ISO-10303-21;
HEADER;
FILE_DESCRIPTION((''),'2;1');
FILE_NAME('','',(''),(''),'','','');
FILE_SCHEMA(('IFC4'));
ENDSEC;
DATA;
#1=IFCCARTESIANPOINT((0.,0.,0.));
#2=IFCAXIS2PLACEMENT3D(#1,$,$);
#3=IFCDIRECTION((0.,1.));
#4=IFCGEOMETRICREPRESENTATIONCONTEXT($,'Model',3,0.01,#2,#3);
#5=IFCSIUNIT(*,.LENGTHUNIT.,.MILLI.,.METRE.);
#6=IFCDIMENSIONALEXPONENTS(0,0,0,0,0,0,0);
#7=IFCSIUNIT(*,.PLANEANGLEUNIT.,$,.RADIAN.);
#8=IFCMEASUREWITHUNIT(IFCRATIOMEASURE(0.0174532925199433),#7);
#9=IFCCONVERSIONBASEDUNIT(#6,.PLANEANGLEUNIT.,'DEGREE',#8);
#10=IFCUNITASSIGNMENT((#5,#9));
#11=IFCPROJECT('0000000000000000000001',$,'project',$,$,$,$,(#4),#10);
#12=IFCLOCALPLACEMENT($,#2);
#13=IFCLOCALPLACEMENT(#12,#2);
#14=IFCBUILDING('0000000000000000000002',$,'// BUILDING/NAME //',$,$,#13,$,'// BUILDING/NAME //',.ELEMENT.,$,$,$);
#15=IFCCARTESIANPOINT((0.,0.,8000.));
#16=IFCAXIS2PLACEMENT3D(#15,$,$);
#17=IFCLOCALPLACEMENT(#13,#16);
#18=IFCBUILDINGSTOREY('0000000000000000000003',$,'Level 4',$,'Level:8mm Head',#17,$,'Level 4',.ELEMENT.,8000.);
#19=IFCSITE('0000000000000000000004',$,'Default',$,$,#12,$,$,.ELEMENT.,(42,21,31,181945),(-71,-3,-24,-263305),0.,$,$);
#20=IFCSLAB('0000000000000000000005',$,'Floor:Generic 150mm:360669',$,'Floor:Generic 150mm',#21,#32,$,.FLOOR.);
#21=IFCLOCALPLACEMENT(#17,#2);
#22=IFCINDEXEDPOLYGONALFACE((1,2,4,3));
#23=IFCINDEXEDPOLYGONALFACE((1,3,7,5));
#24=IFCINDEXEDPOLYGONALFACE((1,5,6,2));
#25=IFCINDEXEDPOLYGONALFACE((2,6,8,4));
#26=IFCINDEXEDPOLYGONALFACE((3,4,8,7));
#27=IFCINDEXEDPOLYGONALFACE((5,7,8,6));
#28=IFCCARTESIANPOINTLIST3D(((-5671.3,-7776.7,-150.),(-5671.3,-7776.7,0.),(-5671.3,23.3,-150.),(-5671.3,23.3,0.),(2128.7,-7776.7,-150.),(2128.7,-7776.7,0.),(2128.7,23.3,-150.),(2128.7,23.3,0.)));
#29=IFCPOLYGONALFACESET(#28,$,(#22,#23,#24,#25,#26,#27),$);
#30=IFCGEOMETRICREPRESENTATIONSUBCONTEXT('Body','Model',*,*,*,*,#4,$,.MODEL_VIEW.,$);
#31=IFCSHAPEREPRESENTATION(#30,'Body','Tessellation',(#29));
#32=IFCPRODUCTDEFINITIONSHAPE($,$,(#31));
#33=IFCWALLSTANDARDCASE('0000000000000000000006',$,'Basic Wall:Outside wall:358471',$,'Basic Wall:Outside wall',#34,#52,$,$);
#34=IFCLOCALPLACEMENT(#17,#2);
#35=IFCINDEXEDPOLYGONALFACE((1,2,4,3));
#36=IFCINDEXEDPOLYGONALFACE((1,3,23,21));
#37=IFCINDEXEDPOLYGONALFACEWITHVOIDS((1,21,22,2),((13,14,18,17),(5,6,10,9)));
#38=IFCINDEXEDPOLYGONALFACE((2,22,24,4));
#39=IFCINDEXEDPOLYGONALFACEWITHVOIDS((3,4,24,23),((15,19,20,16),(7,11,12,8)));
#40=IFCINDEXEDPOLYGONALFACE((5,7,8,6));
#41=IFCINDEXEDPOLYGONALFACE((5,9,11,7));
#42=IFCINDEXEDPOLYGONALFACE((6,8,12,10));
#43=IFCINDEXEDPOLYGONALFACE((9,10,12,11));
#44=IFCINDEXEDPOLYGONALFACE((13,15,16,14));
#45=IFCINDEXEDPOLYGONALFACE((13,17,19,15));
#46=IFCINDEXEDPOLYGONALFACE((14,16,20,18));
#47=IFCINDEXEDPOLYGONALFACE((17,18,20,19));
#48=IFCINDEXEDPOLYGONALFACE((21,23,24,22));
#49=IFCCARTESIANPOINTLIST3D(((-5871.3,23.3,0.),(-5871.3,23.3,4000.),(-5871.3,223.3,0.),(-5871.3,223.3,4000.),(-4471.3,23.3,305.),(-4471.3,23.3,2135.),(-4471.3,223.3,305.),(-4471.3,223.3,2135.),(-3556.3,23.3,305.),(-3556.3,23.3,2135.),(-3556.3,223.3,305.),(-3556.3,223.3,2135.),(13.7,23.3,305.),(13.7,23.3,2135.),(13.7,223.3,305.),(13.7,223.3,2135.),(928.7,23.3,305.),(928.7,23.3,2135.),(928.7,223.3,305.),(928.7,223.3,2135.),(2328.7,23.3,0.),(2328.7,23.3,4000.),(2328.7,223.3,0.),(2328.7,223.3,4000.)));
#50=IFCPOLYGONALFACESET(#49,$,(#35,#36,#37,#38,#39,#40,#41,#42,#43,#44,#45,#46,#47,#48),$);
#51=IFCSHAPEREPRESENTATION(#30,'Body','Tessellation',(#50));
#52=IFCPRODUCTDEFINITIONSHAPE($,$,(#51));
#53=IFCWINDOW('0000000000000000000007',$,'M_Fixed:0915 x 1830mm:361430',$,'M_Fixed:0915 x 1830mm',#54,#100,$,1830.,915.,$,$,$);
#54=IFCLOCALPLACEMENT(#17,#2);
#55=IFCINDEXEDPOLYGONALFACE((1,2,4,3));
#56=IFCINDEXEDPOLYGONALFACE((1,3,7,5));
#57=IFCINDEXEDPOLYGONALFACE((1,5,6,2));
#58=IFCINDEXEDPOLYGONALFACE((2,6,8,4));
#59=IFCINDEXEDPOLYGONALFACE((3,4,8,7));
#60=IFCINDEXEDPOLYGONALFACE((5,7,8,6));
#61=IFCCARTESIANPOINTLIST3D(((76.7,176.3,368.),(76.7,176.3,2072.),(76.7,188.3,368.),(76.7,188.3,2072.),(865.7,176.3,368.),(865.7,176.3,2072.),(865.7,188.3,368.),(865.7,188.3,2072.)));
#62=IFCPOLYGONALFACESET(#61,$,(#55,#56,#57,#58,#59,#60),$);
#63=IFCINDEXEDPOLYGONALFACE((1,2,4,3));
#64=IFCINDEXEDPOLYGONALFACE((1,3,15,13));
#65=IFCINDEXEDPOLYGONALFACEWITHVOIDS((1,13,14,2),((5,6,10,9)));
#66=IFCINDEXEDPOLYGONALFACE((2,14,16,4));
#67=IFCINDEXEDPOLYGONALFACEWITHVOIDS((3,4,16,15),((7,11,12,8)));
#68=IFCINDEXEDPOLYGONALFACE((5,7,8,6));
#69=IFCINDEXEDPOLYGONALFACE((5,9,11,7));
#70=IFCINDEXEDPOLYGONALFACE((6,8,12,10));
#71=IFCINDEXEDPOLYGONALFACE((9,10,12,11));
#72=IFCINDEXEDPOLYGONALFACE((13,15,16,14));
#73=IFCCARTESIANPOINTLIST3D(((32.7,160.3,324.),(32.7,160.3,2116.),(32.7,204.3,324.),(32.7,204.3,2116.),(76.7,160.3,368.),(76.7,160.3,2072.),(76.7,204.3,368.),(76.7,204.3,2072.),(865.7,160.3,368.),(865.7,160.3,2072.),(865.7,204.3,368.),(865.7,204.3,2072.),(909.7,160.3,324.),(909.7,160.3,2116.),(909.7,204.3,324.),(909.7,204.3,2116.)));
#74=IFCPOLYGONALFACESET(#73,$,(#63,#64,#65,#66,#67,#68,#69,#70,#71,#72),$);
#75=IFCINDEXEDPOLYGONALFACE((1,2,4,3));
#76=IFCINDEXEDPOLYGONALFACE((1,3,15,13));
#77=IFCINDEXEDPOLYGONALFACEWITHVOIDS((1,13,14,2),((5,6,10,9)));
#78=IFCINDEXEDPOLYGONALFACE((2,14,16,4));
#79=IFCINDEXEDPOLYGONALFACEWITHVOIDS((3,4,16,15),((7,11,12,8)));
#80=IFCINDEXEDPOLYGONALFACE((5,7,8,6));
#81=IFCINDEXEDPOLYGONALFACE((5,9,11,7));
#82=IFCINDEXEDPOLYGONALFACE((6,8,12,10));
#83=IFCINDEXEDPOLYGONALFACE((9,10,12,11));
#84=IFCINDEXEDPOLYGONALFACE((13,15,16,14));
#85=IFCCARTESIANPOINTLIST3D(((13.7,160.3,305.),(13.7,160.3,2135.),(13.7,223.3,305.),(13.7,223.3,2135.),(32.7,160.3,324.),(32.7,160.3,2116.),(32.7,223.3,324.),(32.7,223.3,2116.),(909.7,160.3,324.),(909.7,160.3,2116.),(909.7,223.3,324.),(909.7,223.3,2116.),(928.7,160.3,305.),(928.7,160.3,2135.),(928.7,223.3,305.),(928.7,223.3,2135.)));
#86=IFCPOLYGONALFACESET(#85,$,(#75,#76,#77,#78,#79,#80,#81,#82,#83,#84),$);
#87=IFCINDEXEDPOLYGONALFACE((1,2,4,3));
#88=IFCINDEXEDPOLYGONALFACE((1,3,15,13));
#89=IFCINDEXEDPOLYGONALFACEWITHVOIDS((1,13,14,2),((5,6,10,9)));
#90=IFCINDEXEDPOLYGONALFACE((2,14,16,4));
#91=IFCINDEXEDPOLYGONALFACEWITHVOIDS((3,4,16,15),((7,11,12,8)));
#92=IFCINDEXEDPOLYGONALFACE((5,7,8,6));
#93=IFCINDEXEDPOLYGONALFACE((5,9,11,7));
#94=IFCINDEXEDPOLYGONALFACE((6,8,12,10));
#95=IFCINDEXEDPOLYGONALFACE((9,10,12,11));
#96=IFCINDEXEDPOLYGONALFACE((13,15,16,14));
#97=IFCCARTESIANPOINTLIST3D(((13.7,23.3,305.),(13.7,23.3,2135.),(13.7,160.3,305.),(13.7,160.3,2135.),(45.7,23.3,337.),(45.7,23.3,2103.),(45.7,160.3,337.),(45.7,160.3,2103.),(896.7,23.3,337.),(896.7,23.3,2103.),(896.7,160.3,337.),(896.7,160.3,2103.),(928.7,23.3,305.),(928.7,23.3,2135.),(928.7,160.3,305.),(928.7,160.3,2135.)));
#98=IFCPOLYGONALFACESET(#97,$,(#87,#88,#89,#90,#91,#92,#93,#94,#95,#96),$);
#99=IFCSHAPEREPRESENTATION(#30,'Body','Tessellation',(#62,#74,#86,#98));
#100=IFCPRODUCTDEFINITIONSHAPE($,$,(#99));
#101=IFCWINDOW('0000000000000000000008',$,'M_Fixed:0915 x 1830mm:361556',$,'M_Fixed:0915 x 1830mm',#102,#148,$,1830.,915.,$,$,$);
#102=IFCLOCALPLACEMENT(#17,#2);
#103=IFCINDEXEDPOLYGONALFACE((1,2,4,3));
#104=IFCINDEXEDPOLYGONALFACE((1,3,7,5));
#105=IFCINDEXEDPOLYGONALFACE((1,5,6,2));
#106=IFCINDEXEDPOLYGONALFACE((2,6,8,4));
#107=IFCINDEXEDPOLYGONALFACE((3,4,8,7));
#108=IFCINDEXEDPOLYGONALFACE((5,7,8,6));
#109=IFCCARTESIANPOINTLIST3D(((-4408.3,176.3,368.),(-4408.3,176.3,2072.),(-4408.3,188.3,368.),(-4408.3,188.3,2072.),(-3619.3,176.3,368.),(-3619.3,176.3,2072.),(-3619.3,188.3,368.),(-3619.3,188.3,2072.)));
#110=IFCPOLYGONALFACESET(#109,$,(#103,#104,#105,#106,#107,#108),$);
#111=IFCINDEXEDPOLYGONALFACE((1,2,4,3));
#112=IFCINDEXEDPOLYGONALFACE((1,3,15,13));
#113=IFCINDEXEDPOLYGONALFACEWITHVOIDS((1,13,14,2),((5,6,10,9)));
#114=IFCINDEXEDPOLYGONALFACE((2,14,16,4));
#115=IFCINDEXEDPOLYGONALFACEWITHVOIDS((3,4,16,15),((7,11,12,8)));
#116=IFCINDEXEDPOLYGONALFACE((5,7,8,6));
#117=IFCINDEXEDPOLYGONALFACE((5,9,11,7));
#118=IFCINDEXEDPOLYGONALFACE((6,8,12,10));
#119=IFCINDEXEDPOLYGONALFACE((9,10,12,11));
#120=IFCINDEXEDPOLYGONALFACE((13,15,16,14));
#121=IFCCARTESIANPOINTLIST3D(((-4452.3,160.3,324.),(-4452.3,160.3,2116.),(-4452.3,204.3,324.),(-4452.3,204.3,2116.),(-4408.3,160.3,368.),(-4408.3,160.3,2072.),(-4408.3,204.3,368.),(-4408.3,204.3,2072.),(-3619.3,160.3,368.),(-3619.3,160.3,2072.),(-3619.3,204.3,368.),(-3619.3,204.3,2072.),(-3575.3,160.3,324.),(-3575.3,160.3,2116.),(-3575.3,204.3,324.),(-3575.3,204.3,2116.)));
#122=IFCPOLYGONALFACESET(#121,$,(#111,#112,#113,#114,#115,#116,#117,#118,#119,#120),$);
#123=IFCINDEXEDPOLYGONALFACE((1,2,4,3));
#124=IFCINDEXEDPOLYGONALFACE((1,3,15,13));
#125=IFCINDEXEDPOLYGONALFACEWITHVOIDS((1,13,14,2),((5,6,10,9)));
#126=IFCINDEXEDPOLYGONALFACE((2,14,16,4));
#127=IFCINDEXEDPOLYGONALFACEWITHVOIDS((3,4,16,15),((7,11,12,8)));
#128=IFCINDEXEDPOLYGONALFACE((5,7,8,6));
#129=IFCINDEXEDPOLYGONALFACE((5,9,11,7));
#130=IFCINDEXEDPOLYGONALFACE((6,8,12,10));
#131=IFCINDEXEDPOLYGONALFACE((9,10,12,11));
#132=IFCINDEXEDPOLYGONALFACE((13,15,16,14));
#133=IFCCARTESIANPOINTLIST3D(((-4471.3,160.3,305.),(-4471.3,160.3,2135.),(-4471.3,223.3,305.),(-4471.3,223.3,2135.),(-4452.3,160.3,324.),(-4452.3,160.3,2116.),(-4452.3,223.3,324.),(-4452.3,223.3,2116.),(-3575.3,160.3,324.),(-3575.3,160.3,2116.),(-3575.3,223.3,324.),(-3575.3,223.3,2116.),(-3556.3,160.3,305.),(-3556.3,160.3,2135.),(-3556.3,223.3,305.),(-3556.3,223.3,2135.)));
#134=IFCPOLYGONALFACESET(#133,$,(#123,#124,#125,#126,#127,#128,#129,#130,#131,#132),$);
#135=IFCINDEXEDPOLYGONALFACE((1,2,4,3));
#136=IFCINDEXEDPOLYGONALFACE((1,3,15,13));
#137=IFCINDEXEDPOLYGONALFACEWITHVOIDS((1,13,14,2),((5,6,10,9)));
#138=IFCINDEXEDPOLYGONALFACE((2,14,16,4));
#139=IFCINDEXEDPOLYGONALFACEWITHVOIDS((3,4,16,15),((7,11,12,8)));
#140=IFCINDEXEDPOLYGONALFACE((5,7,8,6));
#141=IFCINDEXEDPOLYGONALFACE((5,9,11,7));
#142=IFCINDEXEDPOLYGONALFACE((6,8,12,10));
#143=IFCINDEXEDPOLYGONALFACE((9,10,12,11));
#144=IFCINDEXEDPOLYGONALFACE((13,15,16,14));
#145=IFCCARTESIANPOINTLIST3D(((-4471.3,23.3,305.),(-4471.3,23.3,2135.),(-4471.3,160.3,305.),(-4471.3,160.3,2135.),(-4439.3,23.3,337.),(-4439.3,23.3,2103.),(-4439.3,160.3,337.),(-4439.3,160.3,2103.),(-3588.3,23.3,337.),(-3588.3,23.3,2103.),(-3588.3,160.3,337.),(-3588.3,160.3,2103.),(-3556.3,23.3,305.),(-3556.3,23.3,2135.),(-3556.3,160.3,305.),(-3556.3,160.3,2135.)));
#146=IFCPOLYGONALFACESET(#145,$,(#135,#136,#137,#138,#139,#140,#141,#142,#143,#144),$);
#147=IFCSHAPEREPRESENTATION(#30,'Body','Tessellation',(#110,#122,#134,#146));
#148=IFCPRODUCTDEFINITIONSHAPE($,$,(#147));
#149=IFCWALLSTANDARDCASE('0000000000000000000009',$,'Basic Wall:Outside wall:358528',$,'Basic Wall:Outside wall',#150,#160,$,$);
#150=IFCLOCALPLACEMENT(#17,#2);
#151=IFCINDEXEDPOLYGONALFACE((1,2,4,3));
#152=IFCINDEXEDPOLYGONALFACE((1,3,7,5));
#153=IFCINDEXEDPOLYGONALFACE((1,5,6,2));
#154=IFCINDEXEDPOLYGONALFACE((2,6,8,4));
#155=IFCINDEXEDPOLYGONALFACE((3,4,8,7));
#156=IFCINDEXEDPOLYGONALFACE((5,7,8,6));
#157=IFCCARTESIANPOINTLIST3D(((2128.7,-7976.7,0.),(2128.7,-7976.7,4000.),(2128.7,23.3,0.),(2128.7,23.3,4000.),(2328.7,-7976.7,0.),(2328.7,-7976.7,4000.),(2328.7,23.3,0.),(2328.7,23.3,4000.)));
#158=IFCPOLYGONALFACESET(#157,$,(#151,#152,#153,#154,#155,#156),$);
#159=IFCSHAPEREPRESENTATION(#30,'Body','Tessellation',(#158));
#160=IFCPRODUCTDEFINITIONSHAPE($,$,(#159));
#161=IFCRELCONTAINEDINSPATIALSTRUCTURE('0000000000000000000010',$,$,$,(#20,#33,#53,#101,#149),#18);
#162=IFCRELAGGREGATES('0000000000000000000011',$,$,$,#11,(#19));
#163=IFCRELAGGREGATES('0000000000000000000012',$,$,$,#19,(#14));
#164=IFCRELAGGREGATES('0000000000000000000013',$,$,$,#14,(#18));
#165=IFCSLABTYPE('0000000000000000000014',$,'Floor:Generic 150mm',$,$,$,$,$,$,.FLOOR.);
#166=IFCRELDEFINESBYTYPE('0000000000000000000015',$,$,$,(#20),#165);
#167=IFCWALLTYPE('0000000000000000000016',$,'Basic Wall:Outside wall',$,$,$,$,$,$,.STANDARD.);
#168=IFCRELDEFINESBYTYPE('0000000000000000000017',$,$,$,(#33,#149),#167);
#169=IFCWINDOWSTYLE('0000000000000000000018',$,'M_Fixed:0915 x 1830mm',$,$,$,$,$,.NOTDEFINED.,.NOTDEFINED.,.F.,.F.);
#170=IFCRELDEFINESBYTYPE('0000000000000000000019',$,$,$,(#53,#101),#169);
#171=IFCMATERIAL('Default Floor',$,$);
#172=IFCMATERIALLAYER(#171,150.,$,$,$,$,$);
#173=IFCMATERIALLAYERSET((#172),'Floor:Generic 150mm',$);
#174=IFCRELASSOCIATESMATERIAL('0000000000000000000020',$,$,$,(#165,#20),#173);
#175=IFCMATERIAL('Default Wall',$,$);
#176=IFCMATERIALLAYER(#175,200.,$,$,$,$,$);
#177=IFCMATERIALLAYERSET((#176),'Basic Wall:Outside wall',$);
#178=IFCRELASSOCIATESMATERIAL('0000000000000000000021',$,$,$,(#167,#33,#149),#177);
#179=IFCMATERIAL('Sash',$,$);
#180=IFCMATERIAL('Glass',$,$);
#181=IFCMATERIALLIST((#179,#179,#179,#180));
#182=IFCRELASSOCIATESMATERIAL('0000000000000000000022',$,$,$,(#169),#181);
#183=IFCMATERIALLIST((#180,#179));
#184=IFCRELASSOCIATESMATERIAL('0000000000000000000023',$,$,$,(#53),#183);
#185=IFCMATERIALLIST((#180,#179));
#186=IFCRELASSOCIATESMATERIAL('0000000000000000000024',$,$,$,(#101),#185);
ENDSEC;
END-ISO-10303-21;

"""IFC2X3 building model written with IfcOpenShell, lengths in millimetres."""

from ifc_helpers import new_model, entity, si_unit, converted_unit, direction, frame, frame_2d, origin, place, context, subcontext, project, spatial, polyline, rectangle, outline, extrude, clip, halfspace, source, transform, mapped, material, material_list, layer, layer_set, layer_usage, type_object, type_shapes, element, fill, save


model = new_model("IFC2X3")

# Units and contexts
model_context = context("Model", 3, precision=0.01, world=origin(), true_north=direction((0.0, 1.0)))
body_context = subcontext(model_context, "Body", "Model", "MODEL_VIEW")
ifc_project = project(units=[si_unit("LENGTHUNIT", "METRE", prefix="MILLI"), converted_unit("PLANEANGLEUNIT", "DEGREE", entity("IfcRatioMeasure", 0.0174532925199433), si_unit("PLANEANGLEUNIT", "RADIAN"), dimensions=[0, 0, 0, 0, 0, 0, 0])], contexts=[model_context])

# Site, building, storey
site_placement = place(None, origin())
site = spatial("IfcSite", under=ifc_project, at=site_placement, Name="Default", CompositionType="ELEMENT", RefLatitude=(42, 21, 31, 181945), RefLongitude=(-71, -3, -24, -263305), RefElevation=0.0)
building_placement = place(site_placement, origin())
building = spatial("IfcBuilding", under=site, at=building_placement, Name="// BUILDING/NAME //", LongName="// BUILDING/NAME //", CompositionType="ELEMENT")
storey_placement = place(building_placement, frame((0.0, 0.0, 8000.0)))
storey = spatial("IfcBuildingStorey", under=building, at=storey_placement, Name="Level 4", ObjectType="Level:8mm Head", LongName="Level 4", CompositionType="ELEMENT", Elevation=8000.0)

# Slab
ifc_material_1 = material(Name="Default Floor")
ifc_layer_1 = layer(ifc_material_1, 150.0)
ifc_layer_set_1 = layer_set([ifc_layer_1], Name="Floor:Generic 150mm")
ifc_layer_usage_1 = layer_usage(ifc_layer_set_1, "AXIS3", "POSITIVE", 0.0)
slab_type = type_object("IfcSlabType", Name="Floor:Generic 150mm", PredefinedType="FLOOR", material=ifc_layer_set_1)
slab_placement = place(storey_placement, origin())
element("IfcSlab", 1, at=slab_placement, inside=storey, type_object=slab_type, material=ifc_layer_usage_1, Name="Floor:Generic 150mm:360669", ObjectType="Floor:Generic 150mm", PredefinedType="FLOOR", context=body_context, shape_type="SweptSolid", body=[
    extrude(rectangle(XDim=7800.0, YDim=7800.0, at=frame_2d((0.0, 0.0), x_axis=(1.0, 0.0))), frame((-1771.3, -3876.7, 0.0), z_axis=(0.0, 0.0, -1.0), x_axis=(0.0, 1.0, 0.0)), (0.0, 0.0, 1.0), 150.0),
])

# Wall, openings, windows
ifc_material_2 = material(Name="Default Wall")
ifc_layer_2 = layer(ifc_material_2, 200.0)
ifc_layer_set_2 = layer_set([ifc_layer_2], Name="Basic Wall:Outside wall")
ifc_layer_usage_2 = layer_usage(ifc_layer_set_2, "AXIS2", "NEGATIVE", 100.0)
wall_type_1 = type_object("IfcWallType", Name="Basic Wall:Outside wall", PredefinedType="STANDARD", material=ifc_layer_set_2)
wall_1_placement = place(storey_placement, frame((-5871.3, 123.3, 0.0)))
wall_1 = element("IfcWallStandardCase", 2, at=wall_1_placement, inside=storey, type_object=wall_type_1, material=ifc_layer_usage_2, Name="Basic Wall:Outside wall:358471", ObjectType="Basic Wall:Outside wall", context=body_context, shape_type="Clipping", body=[
    clip(extrude(rectangle(XDim=8200.0, YDim=200.0, at=frame_2d((4100.0, 0.0), x_axis=(-1.0, 0.0))), origin(), (0.0, 0.0, 1.0), 4000.0), halfspace(frame((0.0, 0.0, -8000.0)), True)),
])
opening_1_placement = place(wall_1_placement, frame((5885.0, -100.0, 305.0)))
opening_1 = element("IfcOpeningElement", 3, at=opening_1_placement, cuts=wall_1, ObjectType="Opening", context=body_context, shape_type="SweptSolid", body=[
    extrude(rectangle(XDim=1830.0, YDim=915.0, at=frame_2d((915.0, 457.5), x_axis=(1.0, 0.0))), frame((0.0, 0.0, 0.0), z_axis=(0.0, 1.0, 0.0), x_axis=(0.0, 0.0, 1.0)), (0.0, 0.0, 1.0), 200.0),
])
opening_2_placement = place(wall_1_placement, frame((1400.0, -100.0, 305.0)))
opening_2 = element("IfcOpeningElement", 4, at=opening_2_placement, cuts=wall_1, ObjectType="Opening", context=body_context, shape_type="SweptSolid", body=[
    extrude(rectangle(XDim=1830.0, YDim=915.0, at=frame_2d((915.0, 457.5), x_axis=(1.0, 0.0))), frame((0.0, 0.0, 0.0), z_axis=(0.0, 1.0, 0.0), x_axis=(0.0, 0.0, 1.0)), (0.0, 0.0, 1.0), 200.0),
])
ifc_material_3 = material(Name="Glass")
ifc_material_4 = material(Name="Sash")
ifc_material_list_1 = material_list([ifc_material_3, ifc_material_4])
ifc_material_list_2 = material_list([ifc_material_4, ifc_material_4, ifc_material_4, ifc_material_3])
window_style = type_object("IfcWindowStyle", Name="M_Fixed:0915 x 1830mm", ConstructionType="NOTDEFINED", OperationType="NOTDEFINED", ParameterTakesPrecedence=False, Sizeable=False, material=ifc_material_list_2)
shared_shape = source(origin(), body_context, "Body", "SweptSolid", [
    extrude(rectangle(XDim=12.0, YDim=789.0, at=frame_2d((0.0, 0.0), x_axis=(1.0, 0.0))), frame((457.5, 159.0, 63.0), z_axis=(0.0, 0.0, 1.0), x_axis=(0.0, -1.0, 0.0)), (0.0, 0.0, 1.0), 1704.0),
    extrude(outline(polyline([(-438.5, -896.0), (438.5, -896.0), (438.5, 896.0), (-438.5, 896.0), (-438.5, -896.0)]), holes=[polyline([(-394.5, -852.0), (-394.5, 852.0), (394.5, 852.0), (394.5, -852.0), (-394.5, -852.0)])]), frame((457.5, 137.0, 915.0), z_axis=(0.0, 1.0, 0.0), x_axis=(1.0, 0.0, 0.0)), (0.0, 0.0, 1.0), 44.0),
    extrude(outline(polyline([(-457.5, -915.0), (457.5, -915.0), (457.5, 915.0), (-457.5, 915.0), (-457.5, -915.0)]), holes=[polyline([(-438.5, -896.0), (-438.5, 896.0), (438.5, 896.0), (438.5, -896.0), (-438.5, -896.0)])]), frame((457.5, 137.0, 915.0), z_axis=(0.0, 1.0, 0.0), x_axis=(1.0, 0.0, 0.0)), (0.0, 0.0, 1.0), 63.0),
    extrude(outline(polyline([(-457.5, -915.0), (457.5, -915.0), (457.5, 915.0), (-457.5, 915.0), (-457.5, -915.0)]), holes=[polyline([(-425.5, -883.0), (-425.5, 883.0), (425.5, 883.0), (425.5, -883.0), (-425.5, -883.0)])]), frame((457.5, 0.0, 915.0), z_axis=(0.0, 1.0, 0.0), x_axis=(1.0, 0.0, 0.0)), (0.0, 0.0, 1.0), 137.0),
])
type_shapes(window_style, [shared_shape])
window_1_placement = place(opening_1_placement, origin())
window_1 = element("IfcWindow", 5, at=window_1_placement, inside=storey, type_object=window_style, material=ifc_material_list_1, Name="M_Fixed:0915 x 1830mm:361430", ObjectType="M_Fixed:0915 x 1830mm", OverallHeight=1830.0, OverallWidth=915.0, context=body_context, shape_type="MappedRepresentation", body=[
    mapped(shared_shape, transform((0.0, 0.0, 0.0), scale=1.0)),
])
fill(opening_1, window_1)
ifc_material_list_3 = material_list([ifc_material_3, ifc_material_4])
window_2_placement = place(opening_2_placement, origin())
window_2 = element("IfcWindow", 6, at=window_2_placement, inside=storey, type_object=window_style, material=ifc_material_list_3, Name="M_Fixed:0915 x 1830mm:361556", ObjectType="M_Fixed:0915 x 1830mm", OverallHeight=1830.0, OverallWidth=915.0, context=body_context, shape_type="MappedRepresentation", body=[
    mapped(shared_shape, transform((0.0, 0.0, 0.0), scale=1.0)),
])
fill(opening_2, window_2)

# Wall
ifc_layer_usage_3 = layer_usage(ifc_layer_set_2, "AXIS2", "NEGATIVE", 100.0)
wall_2_placement = place(storey_placement, frame((2228.7, 23.3, 0.0), z_axis=(0.0, 0.0, 1.0), x_axis=(0.0, -1.0, 0.0)))
element("IfcWallStandardCase", 7, at=wall_2_placement, inside=storey, type_object=wall_type_1, material=ifc_layer_usage_3, Name="Basic Wall:Outside wall:358528", ObjectType="Basic Wall:Outside wall", context=body_context, shape_type="Clipping", body=[
    clip(extrude(rectangle(XDim=8000.0, YDim=200.0, at=frame_2d((4000.0, 0.0), x_axis=(-1.0, 0.0))), origin(), (0.0, 0.0, 1.0), 4000.0), halfspace(frame((0.0, 0.0, -8000.0)), True)),
])

save(model, "model.ifc")
